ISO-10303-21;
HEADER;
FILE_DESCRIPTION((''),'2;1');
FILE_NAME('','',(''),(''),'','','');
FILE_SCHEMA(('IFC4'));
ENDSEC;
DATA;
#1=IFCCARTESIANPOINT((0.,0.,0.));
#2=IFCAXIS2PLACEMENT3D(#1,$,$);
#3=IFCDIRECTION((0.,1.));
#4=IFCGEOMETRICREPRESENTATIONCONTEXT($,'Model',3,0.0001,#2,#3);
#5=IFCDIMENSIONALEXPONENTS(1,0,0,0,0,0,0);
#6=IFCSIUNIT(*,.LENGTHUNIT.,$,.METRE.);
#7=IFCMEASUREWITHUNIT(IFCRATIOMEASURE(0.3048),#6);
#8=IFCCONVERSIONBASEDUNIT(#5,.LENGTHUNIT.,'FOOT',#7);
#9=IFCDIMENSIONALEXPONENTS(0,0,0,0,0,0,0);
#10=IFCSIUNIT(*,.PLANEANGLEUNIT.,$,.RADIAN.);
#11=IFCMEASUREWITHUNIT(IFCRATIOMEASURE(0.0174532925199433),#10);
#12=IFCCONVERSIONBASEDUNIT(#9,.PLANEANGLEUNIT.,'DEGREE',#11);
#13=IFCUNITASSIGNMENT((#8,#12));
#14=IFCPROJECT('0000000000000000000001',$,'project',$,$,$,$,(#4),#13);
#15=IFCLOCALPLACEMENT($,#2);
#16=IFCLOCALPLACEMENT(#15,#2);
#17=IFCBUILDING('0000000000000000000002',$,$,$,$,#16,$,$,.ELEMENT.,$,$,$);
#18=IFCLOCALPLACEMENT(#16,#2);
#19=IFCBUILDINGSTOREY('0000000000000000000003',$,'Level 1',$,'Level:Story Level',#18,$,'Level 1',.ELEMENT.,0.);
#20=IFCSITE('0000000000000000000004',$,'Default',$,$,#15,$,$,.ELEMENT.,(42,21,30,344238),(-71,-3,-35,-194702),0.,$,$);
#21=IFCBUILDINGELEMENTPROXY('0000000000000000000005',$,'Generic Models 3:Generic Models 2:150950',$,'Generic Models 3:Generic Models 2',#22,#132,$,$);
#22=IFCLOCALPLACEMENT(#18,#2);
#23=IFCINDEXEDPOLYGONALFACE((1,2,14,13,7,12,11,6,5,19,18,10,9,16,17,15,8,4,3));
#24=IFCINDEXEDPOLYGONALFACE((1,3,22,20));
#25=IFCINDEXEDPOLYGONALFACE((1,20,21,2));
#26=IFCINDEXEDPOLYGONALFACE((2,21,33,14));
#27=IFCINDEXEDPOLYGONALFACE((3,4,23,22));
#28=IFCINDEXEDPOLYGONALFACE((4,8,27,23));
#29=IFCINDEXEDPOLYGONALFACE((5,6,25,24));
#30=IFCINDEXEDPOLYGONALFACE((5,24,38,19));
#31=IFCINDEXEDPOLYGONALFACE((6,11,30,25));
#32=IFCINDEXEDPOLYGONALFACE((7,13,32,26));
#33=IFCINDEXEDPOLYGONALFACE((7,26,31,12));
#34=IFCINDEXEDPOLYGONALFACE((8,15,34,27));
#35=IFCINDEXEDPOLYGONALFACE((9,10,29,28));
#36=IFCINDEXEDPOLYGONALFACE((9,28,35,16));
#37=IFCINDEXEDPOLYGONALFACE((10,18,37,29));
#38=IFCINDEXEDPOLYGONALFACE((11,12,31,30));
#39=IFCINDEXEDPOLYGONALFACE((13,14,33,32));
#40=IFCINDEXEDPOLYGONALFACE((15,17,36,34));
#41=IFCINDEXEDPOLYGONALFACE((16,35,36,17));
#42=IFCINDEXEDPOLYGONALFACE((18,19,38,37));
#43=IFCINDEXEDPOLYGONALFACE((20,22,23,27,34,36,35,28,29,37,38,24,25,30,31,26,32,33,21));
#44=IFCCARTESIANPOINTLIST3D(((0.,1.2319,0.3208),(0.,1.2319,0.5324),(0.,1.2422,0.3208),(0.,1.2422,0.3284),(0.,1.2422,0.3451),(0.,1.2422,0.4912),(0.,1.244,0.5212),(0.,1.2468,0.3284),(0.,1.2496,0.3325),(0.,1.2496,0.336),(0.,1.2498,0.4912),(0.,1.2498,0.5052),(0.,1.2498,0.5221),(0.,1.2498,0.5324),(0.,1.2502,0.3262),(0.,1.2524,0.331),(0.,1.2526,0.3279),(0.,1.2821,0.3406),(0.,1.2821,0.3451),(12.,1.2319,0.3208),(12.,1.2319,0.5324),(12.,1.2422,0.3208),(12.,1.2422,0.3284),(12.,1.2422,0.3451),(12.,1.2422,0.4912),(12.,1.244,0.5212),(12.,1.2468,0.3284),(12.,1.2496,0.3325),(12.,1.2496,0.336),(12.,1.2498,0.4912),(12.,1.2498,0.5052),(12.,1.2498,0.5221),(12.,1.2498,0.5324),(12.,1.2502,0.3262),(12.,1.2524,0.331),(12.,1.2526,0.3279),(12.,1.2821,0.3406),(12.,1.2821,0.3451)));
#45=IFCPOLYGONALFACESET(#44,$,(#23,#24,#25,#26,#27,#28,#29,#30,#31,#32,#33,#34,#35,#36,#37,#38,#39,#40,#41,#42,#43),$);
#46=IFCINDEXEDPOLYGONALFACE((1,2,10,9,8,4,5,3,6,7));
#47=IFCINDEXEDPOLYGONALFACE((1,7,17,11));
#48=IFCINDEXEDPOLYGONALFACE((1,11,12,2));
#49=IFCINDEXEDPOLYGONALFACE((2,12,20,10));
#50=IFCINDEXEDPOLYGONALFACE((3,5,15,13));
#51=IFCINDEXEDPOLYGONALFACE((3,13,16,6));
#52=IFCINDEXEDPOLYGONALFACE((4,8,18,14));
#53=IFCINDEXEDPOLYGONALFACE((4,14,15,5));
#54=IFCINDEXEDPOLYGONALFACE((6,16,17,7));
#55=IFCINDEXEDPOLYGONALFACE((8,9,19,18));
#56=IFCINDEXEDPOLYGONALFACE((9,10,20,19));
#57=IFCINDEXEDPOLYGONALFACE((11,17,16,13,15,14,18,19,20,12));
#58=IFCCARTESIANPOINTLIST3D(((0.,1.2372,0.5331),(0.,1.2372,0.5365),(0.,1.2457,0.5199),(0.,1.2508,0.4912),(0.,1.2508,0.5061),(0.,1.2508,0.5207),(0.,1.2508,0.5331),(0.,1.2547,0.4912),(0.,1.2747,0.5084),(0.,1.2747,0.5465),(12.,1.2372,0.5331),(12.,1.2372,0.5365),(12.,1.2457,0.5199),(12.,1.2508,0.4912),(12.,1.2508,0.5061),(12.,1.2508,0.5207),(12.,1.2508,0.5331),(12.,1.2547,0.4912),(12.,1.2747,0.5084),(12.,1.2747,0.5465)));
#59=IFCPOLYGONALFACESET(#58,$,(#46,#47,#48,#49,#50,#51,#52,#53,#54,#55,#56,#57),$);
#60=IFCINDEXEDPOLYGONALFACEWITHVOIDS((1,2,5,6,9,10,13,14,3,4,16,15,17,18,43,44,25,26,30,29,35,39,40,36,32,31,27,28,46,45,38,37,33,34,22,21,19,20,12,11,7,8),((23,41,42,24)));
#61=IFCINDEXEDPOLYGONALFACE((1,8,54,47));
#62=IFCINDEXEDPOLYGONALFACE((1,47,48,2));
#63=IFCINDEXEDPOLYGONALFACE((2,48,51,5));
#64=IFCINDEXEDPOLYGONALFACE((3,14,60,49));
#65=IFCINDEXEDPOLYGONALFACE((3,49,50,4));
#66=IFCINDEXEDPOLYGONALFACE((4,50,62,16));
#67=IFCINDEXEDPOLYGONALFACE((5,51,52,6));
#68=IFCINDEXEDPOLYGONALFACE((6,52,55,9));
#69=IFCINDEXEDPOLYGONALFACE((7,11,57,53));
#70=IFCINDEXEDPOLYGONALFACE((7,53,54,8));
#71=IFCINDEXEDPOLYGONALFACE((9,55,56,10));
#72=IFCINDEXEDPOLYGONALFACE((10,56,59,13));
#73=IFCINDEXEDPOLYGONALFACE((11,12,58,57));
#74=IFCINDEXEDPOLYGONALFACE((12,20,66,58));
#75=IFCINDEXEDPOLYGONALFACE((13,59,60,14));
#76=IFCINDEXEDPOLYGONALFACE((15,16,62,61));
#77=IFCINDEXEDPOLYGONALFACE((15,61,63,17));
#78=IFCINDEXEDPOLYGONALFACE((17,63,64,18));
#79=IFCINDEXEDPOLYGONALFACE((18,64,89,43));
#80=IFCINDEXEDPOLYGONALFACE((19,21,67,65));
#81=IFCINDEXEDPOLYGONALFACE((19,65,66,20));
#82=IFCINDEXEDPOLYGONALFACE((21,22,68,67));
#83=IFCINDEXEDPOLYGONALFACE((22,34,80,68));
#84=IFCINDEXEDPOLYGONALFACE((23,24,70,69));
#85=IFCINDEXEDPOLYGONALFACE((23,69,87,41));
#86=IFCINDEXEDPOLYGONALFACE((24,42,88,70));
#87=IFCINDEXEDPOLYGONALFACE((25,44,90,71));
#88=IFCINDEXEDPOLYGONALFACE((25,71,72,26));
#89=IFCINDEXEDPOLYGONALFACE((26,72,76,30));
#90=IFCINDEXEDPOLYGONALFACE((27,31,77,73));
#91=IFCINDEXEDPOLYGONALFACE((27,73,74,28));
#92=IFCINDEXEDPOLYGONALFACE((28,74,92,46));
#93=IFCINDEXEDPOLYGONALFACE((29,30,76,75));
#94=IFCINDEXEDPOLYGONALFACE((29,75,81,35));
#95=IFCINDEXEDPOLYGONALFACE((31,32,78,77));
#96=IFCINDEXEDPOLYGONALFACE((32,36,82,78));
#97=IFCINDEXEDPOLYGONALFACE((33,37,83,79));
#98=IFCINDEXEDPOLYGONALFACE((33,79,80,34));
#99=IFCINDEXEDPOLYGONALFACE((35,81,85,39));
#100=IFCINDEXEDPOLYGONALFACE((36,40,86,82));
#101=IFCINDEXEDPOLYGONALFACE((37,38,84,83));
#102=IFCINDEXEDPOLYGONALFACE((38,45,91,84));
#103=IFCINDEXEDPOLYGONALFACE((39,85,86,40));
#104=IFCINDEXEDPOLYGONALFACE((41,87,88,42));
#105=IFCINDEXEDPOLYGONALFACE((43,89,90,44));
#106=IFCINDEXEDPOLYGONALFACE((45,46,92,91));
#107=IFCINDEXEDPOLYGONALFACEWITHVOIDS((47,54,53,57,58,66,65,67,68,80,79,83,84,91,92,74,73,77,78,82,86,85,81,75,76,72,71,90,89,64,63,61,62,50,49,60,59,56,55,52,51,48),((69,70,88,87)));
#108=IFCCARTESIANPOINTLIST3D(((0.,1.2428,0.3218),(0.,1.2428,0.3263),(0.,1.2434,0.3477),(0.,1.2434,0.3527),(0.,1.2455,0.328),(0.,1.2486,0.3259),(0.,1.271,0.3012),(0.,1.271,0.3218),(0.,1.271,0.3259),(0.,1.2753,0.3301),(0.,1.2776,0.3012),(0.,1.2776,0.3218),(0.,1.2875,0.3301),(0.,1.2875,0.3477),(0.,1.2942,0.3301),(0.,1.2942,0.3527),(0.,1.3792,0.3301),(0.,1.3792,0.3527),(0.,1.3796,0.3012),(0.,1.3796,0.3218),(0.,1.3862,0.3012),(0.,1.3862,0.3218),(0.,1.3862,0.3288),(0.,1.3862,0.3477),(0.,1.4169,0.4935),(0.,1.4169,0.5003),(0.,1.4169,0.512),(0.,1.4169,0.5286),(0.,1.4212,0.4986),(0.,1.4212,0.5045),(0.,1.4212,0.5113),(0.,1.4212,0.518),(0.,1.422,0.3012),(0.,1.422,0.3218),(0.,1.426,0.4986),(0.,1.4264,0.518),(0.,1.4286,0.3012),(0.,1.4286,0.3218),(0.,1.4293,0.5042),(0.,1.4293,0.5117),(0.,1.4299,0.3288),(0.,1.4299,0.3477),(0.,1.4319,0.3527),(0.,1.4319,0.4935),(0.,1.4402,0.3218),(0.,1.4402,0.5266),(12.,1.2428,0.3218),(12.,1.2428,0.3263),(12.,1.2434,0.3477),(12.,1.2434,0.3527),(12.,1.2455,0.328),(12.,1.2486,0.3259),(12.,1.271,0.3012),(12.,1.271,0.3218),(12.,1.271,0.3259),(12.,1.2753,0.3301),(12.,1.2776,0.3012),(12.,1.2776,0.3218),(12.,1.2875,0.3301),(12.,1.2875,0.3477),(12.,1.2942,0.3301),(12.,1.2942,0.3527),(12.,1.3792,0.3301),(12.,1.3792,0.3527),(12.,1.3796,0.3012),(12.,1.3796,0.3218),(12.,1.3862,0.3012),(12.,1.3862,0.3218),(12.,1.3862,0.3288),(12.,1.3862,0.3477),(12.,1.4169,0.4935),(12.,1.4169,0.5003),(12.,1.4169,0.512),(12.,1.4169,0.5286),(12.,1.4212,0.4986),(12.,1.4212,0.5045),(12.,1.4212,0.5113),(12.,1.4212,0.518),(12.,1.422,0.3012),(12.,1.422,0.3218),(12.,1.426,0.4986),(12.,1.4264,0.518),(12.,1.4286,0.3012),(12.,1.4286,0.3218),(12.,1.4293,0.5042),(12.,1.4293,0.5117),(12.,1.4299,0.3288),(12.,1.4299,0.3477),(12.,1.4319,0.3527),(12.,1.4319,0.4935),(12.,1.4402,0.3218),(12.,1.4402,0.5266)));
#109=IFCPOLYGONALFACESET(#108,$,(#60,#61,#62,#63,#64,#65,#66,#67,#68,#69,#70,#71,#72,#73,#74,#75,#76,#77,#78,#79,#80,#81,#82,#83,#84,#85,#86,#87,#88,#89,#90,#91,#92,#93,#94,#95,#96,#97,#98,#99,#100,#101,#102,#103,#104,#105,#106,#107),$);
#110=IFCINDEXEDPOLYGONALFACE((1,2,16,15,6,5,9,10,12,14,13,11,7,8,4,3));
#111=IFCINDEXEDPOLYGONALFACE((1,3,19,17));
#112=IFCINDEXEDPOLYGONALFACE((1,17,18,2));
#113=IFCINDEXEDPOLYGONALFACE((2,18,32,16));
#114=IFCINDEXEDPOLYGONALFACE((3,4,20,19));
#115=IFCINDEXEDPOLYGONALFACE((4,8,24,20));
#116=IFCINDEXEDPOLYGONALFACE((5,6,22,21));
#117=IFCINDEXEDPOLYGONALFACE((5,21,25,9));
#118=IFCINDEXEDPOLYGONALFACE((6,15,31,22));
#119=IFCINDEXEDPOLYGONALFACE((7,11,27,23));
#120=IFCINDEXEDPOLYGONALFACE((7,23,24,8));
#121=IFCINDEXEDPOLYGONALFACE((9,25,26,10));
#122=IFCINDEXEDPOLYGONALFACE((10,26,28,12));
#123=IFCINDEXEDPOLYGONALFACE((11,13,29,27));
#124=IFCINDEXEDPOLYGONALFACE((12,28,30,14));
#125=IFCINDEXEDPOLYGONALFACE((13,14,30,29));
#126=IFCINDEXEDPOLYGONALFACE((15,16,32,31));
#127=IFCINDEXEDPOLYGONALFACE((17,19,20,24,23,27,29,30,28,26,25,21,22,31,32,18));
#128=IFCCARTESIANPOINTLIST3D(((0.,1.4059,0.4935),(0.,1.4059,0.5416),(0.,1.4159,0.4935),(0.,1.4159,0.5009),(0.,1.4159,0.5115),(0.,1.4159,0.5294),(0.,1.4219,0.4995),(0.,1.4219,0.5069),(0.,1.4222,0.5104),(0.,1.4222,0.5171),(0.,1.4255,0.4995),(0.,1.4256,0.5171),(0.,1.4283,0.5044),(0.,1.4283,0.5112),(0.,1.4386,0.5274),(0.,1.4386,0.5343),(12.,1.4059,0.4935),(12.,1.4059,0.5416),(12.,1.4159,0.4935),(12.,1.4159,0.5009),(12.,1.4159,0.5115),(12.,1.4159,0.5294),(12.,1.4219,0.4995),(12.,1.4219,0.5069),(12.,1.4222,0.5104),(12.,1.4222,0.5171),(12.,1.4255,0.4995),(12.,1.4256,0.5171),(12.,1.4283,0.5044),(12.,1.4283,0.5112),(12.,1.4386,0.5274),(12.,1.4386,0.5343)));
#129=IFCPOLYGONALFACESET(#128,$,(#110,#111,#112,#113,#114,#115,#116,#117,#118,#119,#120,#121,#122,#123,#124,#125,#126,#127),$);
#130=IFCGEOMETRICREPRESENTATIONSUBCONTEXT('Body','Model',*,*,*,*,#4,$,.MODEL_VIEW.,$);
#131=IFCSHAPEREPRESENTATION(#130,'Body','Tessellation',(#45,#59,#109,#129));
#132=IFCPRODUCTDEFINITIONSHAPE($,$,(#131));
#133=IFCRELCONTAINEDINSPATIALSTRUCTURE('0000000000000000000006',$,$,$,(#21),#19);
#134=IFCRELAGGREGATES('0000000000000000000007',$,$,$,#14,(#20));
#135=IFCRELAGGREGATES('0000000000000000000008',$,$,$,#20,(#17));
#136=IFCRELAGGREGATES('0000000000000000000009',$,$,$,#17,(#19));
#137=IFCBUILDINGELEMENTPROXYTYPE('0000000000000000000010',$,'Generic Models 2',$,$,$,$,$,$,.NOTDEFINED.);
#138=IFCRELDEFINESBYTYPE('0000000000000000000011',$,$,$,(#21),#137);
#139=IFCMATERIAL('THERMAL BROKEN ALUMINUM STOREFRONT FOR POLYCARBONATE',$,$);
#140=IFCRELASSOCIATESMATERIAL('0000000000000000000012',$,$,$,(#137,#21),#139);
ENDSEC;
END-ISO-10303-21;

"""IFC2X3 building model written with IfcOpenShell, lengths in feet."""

from ifc_helpers import new_model, entity, si_unit, converted_unit, direction, frame, origin, place, context, subcontext, project, spatial, polyline, outline, extrude, source, transform, mapped, material, type_object, type_shapes, element, save


model = new_model("IFC2X3")

# Units and contexts
model_context = context("Model", 3, precision=0.0001, world=origin(), true_north=direction((0.0, 1.0)))
body_context = subcontext(model_context, "Body", "Model", "MODEL_VIEW")
ifc_project = project(units=[converted_unit("LENGTHUNIT", "FOOT", entity("IfcRatioMeasure", 0.3048), si_unit("LENGTHUNIT", "METRE"), dimensions=[1, 0, 0, 0, 0, 0, 0]), converted_unit("PLANEANGLEUNIT", "DEGREE", entity("IfcRatioMeasure", 0.0174532925199433), si_unit("PLANEANGLEUNIT", "RADIAN"), dimensions=[0, 0, 0, 0, 0, 0, 0])], contexts=[model_context])

# Site, building, storey
site_placement = place(None, origin())
site = spatial("IfcSite", under=ifc_project, at=site_placement, Name="Default", CompositionType="ELEMENT", RefLatitude=(42, 21, 30, 344238), RefLongitude=(-71, -3, -35, -194702), RefElevation=0.0)
building_placement = place(site_placement, origin())
building = spatial("IfcBuilding", under=site, at=building_placement, CompositionType="ELEMENT")
storey_placement = place(building_placement, origin())
storey = spatial("IfcBuildingStorey", under=building, at=storey_placement, Name="Level 1", ObjectType="Level:Story Level", LongName="Level 1", CompositionType="ELEMENT", Elevation=0.0)

# Building element proxy
ifc_material = material(Name="THERMAL BROKEN ALUMINUM STOREFRONT FOR POLYCARBONATE")
building_element_proxy_type_1 = type_object("IfcBuildingElementProxyType", Name="Generic Models 2", PredefinedType="NOTDEFINED", material=ifc_material)
shared_shape_1 = source(origin(), body_context, "Body", "SweptSolid", [
    extrude(outline(polyline([(-0.0355, -0.058), (-0.0371, -0.0606), (-0.0358, -0.0632), (-0.0318, -0.063), (-0.0278, -0.0652), (-0.0315, -0.0718), (-0.0224, -0.0768), (0.0802, 0.1083), (0.0645, 0.1169), (0.0595, 0.1079), (0.0642, 0.1042), (0.0513, 0.0931), (0.0445, 0.0809), (0.0512, 0.0772), (-0.0197, -0.0506), (-0.0545, -0.0312), (-0.0567, -0.0352), (-0.0306, -0.055), (-0.0322, -0.058), (-0.0355, -0.058)])), frame((0.0, 1.2495, 0.3989), z_axis=(-1.0, 0.0, 0.0), x_axis=(0.0, -0.874529, 0.484974)), (0.0, 0.0, -1.0), 12.0),
    extrude(outline(polyline([(-0.0178, -0.0155), (-0.0144, -0.0155), (-0.0144, -0.002), (-0.0021, -0.002), (-0.0012, -0.007), (0.0126, -0.002), (0.0275, -0.002), (0.0275, 0.002), (0.0102, 0.022), (-0.0278, 0.022), (-0.0178, -0.0155)])), frame((0.0, 1.2527, 0.5187), z_axis=(1.0, 0.0, 0.0), x_axis=(0.0, 0.0, -1.0)), (0.0, 0.0, 1.0), 12.0),
    extrude(outline(polyline([(-0.107, -0.073), (-0.107, -0.058), (-0.1137, -0.058), (-0.118, -0.0623), (-0.1121, -0.0623), (-0.1121, -0.0672), (-0.1177, -0.0704), (-0.1252, -0.0704), (-0.1315, -0.0675), (-0.1315, -0.0623), (-0.1248, -0.0623), (-0.1255, -0.058), (-0.142, -0.058), (-0.1401, -0.0814), (0.0647, -0.0814), (0.0647, -0.0697), (0.0853, -0.0697), (0.0853, -0.0631), (0.0647, -0.0631), (0.0647, -0.0273), (0.0853, -0.0273), (0.0853, -0.0207), (0.0647, -0.0207), (0.0647, 0.0812), (0.0853, 0.0812), (0.0853, 0.0878), (0.0647, 0.0878), (0.0647, 0.1161), (0.0603, 0.1161), (0.0585, 0.1133), (0.0606, 0.1102), (0.0606, 0.0878), (0.0564, 0.0836), (0.0564, 0.0713), (0.0389, 0.0713), (0.0389, 0.1155), (0.0338, 0.1155), (0.0338, 0.0647), (0.0564, 0.0647), (0.0564, -0.0203), (0.0338, -0.0203), (0.0338, -0.073), (-0.107, -0.073)]), holes=[polyline([(0.0577, -0.0711), (0.0389, -0.0711), (0.0389, -0.0273), (0.0577, -0.0273), (0.0577, -0.0711)])]), frame((0.0, 1.3589, 0.3865), z_axis=(-1.0, 0.0, 0.0), x_axis=(0.0, 0.0, -1.0)), (0.0, 0.0, -1.0), 12.0),
    extrude(outline(polyline([(-0.0292, -0.0159), (0.0189, -0.0159), (0.0189, -0.0059), (0.0115, -0.0059), (0.0055, 0.0001), (0.0129, 0.0001), (0.0129, 0.0037), (0.008, 0.0065), (0.0012, 0.0065), (-0.0047, 0.0038), (-0.0047, 0.0004), (0.002, 0.0004), (0.0009, -0.0059), (-0.017, -0.0059), (-0.015, 0.0168), (-0.0219, 0.0168), (-0.0292, -0.0159)])), frame((0.0, 1.4218, 0.5124), z_axis=(1.0, 0.0, 0.0), x_axis=(0.0, 0.0, -1.0)), (0.0, 0.0, 1.0), 12.0),
])
type_shapes(building_element_proxy_type_1, [shared_shape_1])
proxy_1_placement = place(storey_placement, origin())
element("IfcBuildingElementProxy", 1, at=proxy_1_placement, inside=storey, type_object=building_element_proxy_type_1, material=ifc_material, Name="Generic Models 3:Generic Models 2:150950", ObjectType="Generic Models 3:Generic Models 2", context=body_context, shape_type="MappedRepresentation", body=[
    mapped(shared_shape_1, transform((0.0, 0.0, 0.0), scale=1.0)),
])

save(model, "model.ifc")
